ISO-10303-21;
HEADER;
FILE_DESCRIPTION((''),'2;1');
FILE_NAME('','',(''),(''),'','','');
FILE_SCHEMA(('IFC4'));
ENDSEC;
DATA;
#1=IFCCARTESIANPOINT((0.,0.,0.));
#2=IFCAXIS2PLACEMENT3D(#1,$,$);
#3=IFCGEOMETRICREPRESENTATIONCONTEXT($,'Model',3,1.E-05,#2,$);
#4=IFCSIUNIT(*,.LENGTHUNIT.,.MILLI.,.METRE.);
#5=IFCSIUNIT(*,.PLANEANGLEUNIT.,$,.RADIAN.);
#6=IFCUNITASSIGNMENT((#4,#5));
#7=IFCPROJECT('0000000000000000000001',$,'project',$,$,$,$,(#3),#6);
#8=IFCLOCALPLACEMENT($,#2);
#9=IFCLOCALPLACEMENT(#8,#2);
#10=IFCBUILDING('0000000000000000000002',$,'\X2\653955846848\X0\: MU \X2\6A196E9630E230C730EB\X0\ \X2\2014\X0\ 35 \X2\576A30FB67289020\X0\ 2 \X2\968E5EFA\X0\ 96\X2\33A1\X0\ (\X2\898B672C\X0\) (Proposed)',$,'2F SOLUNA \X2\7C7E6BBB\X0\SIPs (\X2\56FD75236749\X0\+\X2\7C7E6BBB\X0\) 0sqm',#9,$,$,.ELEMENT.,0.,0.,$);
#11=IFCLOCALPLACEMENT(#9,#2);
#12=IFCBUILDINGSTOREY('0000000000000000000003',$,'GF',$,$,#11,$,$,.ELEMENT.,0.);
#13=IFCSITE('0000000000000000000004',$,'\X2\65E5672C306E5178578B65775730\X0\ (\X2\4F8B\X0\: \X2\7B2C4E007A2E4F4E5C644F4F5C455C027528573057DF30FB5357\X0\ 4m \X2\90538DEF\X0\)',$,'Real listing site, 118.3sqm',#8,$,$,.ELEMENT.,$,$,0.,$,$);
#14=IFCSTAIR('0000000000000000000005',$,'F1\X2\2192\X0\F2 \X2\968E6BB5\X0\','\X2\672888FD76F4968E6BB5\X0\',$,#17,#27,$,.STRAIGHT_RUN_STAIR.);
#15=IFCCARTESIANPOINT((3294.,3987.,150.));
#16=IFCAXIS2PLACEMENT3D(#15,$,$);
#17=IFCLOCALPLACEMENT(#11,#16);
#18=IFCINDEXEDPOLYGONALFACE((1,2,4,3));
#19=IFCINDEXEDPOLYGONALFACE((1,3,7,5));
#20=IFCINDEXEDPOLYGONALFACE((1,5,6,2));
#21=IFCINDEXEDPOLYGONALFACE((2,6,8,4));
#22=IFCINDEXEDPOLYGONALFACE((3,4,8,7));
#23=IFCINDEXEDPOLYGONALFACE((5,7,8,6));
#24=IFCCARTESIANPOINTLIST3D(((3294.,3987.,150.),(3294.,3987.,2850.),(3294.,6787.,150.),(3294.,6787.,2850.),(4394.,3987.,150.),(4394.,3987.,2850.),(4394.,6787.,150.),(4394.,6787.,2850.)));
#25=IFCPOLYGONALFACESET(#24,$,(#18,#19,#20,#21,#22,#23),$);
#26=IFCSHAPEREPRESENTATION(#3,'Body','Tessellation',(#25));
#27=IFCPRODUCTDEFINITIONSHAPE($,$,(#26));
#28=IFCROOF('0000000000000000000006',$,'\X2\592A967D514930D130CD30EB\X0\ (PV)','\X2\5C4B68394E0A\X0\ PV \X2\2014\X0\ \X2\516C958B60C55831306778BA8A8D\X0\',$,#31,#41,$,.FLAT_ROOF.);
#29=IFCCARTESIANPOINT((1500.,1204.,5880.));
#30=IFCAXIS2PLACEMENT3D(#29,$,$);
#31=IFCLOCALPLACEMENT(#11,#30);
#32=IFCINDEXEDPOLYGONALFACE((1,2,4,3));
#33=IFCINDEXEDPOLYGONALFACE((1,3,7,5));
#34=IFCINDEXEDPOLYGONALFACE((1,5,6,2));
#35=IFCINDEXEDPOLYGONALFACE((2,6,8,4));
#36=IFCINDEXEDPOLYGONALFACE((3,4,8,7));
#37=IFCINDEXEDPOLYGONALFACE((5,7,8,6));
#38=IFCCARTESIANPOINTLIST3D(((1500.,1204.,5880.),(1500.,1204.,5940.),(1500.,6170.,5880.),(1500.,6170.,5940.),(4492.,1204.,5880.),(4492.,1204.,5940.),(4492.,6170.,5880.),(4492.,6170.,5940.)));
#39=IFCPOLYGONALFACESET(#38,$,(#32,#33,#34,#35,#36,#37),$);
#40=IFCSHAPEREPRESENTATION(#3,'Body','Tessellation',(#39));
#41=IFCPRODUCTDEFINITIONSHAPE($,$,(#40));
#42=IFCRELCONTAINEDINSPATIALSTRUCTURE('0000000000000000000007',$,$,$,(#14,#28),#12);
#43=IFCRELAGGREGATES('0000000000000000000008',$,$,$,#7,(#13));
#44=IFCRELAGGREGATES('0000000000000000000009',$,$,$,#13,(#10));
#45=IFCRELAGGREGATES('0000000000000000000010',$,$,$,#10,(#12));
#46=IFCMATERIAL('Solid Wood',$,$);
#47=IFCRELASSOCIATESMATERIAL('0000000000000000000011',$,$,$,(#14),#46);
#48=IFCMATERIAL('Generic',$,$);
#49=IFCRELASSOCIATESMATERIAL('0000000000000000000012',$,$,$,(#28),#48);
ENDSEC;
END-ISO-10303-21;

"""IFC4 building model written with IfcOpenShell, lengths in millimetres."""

from ifc_helpers import new_model, si_unit, frame, frame_2d, origin, place, context, project, spatial, rectangle, extrude, material, element, save


model = new_model("IFC4")

# Units and contexts
model_context = context("Model", 3, precision=1e-05, world=origin())
ifc_project = project(units=[si_unit("LENGTHUNIT", "METRE", prefix="MILLI"), si_unit("PLANEANGLEUNIT", "RADIAN")], contexts=[model_context])

# Site, building, storey
site_placement = place(None, origin())
site = spatial("IfcSite", under=ifc_project, at=site_placement, Name="日本の典型敷地 (例: 第一種低層住居専用地域・南 4m 道路)", ObjectType="Real listing site, 118.3sqm", CompositionType="ELEMENT", RefElevation=0.0)
building_placement = place(site_placement, origin())
building = spatial("IfcBuilding", under=site, at=building_placement, Name="改善案: MU 標準モデル — 35 坪・木造 2 階建 96㎡ (見本) (Proposed)", ObjectType="2F SOLUNA 籾殻SIPs (国産杉+籾殻) 0sqm", CompositionType="ELEMENT", ElevationOfRefHeight=0.0, ElevationOfTerrain=0.0)
storey_placement = place(building_placement, origin())
storey = spatial("IfcBuildingStorey", under=building, at=storey_placement, Name="GF", CompositionType="ELEMENT", Elevation=0.0)

# Shared definitions
ifc_material_1 = material(Name="Generic")

# Stair
ifc_material_2 = material(Name="Solid Wood")
stair_placement = place(storey_placement, frame((3294.0, 3987.0, 150.0)))
element("IfcStair", 1, at=stair_placement, inside=storey, material=ifc_material_2, Name="F1→F2 階段", Description="木製直階段", PredefinedType="STRAIGHT_RUN_STAIR", context=model_context, shape_type="SweptSolid", body=[
    extrude(rectangle(XDim=1100.0, YDim=2800.0, at=frame_2d((550.0, 1400.0))), frame((3294.0, 3987.0, 150.0)), (0.0, 0.0, 1.0), 2700.0),
])

# Roof
roof_placement = place(storey_placement, frame((1500.0, 1204.0, 5880.0)))
element("IfcRoof", 2, at=roof_placement, inside=storey, material=ifc_material_1, Name="太陽光パネル (PV)", Description="屋根上 PV — 公開情報で確認", PredefinedType="FLAT_ROOF", context=model_context, shape_type="SweptSolid", body=[
    extrude(rectangle(XDim=2992.0, YDim=4966.0, at=frame_2d((1496.0, 2483.0))), frame((1500.0, 1204.0, 5880.0)), (0.0, 0.0, 1.0), 60.0),
])

save(model, "model.ifc")
